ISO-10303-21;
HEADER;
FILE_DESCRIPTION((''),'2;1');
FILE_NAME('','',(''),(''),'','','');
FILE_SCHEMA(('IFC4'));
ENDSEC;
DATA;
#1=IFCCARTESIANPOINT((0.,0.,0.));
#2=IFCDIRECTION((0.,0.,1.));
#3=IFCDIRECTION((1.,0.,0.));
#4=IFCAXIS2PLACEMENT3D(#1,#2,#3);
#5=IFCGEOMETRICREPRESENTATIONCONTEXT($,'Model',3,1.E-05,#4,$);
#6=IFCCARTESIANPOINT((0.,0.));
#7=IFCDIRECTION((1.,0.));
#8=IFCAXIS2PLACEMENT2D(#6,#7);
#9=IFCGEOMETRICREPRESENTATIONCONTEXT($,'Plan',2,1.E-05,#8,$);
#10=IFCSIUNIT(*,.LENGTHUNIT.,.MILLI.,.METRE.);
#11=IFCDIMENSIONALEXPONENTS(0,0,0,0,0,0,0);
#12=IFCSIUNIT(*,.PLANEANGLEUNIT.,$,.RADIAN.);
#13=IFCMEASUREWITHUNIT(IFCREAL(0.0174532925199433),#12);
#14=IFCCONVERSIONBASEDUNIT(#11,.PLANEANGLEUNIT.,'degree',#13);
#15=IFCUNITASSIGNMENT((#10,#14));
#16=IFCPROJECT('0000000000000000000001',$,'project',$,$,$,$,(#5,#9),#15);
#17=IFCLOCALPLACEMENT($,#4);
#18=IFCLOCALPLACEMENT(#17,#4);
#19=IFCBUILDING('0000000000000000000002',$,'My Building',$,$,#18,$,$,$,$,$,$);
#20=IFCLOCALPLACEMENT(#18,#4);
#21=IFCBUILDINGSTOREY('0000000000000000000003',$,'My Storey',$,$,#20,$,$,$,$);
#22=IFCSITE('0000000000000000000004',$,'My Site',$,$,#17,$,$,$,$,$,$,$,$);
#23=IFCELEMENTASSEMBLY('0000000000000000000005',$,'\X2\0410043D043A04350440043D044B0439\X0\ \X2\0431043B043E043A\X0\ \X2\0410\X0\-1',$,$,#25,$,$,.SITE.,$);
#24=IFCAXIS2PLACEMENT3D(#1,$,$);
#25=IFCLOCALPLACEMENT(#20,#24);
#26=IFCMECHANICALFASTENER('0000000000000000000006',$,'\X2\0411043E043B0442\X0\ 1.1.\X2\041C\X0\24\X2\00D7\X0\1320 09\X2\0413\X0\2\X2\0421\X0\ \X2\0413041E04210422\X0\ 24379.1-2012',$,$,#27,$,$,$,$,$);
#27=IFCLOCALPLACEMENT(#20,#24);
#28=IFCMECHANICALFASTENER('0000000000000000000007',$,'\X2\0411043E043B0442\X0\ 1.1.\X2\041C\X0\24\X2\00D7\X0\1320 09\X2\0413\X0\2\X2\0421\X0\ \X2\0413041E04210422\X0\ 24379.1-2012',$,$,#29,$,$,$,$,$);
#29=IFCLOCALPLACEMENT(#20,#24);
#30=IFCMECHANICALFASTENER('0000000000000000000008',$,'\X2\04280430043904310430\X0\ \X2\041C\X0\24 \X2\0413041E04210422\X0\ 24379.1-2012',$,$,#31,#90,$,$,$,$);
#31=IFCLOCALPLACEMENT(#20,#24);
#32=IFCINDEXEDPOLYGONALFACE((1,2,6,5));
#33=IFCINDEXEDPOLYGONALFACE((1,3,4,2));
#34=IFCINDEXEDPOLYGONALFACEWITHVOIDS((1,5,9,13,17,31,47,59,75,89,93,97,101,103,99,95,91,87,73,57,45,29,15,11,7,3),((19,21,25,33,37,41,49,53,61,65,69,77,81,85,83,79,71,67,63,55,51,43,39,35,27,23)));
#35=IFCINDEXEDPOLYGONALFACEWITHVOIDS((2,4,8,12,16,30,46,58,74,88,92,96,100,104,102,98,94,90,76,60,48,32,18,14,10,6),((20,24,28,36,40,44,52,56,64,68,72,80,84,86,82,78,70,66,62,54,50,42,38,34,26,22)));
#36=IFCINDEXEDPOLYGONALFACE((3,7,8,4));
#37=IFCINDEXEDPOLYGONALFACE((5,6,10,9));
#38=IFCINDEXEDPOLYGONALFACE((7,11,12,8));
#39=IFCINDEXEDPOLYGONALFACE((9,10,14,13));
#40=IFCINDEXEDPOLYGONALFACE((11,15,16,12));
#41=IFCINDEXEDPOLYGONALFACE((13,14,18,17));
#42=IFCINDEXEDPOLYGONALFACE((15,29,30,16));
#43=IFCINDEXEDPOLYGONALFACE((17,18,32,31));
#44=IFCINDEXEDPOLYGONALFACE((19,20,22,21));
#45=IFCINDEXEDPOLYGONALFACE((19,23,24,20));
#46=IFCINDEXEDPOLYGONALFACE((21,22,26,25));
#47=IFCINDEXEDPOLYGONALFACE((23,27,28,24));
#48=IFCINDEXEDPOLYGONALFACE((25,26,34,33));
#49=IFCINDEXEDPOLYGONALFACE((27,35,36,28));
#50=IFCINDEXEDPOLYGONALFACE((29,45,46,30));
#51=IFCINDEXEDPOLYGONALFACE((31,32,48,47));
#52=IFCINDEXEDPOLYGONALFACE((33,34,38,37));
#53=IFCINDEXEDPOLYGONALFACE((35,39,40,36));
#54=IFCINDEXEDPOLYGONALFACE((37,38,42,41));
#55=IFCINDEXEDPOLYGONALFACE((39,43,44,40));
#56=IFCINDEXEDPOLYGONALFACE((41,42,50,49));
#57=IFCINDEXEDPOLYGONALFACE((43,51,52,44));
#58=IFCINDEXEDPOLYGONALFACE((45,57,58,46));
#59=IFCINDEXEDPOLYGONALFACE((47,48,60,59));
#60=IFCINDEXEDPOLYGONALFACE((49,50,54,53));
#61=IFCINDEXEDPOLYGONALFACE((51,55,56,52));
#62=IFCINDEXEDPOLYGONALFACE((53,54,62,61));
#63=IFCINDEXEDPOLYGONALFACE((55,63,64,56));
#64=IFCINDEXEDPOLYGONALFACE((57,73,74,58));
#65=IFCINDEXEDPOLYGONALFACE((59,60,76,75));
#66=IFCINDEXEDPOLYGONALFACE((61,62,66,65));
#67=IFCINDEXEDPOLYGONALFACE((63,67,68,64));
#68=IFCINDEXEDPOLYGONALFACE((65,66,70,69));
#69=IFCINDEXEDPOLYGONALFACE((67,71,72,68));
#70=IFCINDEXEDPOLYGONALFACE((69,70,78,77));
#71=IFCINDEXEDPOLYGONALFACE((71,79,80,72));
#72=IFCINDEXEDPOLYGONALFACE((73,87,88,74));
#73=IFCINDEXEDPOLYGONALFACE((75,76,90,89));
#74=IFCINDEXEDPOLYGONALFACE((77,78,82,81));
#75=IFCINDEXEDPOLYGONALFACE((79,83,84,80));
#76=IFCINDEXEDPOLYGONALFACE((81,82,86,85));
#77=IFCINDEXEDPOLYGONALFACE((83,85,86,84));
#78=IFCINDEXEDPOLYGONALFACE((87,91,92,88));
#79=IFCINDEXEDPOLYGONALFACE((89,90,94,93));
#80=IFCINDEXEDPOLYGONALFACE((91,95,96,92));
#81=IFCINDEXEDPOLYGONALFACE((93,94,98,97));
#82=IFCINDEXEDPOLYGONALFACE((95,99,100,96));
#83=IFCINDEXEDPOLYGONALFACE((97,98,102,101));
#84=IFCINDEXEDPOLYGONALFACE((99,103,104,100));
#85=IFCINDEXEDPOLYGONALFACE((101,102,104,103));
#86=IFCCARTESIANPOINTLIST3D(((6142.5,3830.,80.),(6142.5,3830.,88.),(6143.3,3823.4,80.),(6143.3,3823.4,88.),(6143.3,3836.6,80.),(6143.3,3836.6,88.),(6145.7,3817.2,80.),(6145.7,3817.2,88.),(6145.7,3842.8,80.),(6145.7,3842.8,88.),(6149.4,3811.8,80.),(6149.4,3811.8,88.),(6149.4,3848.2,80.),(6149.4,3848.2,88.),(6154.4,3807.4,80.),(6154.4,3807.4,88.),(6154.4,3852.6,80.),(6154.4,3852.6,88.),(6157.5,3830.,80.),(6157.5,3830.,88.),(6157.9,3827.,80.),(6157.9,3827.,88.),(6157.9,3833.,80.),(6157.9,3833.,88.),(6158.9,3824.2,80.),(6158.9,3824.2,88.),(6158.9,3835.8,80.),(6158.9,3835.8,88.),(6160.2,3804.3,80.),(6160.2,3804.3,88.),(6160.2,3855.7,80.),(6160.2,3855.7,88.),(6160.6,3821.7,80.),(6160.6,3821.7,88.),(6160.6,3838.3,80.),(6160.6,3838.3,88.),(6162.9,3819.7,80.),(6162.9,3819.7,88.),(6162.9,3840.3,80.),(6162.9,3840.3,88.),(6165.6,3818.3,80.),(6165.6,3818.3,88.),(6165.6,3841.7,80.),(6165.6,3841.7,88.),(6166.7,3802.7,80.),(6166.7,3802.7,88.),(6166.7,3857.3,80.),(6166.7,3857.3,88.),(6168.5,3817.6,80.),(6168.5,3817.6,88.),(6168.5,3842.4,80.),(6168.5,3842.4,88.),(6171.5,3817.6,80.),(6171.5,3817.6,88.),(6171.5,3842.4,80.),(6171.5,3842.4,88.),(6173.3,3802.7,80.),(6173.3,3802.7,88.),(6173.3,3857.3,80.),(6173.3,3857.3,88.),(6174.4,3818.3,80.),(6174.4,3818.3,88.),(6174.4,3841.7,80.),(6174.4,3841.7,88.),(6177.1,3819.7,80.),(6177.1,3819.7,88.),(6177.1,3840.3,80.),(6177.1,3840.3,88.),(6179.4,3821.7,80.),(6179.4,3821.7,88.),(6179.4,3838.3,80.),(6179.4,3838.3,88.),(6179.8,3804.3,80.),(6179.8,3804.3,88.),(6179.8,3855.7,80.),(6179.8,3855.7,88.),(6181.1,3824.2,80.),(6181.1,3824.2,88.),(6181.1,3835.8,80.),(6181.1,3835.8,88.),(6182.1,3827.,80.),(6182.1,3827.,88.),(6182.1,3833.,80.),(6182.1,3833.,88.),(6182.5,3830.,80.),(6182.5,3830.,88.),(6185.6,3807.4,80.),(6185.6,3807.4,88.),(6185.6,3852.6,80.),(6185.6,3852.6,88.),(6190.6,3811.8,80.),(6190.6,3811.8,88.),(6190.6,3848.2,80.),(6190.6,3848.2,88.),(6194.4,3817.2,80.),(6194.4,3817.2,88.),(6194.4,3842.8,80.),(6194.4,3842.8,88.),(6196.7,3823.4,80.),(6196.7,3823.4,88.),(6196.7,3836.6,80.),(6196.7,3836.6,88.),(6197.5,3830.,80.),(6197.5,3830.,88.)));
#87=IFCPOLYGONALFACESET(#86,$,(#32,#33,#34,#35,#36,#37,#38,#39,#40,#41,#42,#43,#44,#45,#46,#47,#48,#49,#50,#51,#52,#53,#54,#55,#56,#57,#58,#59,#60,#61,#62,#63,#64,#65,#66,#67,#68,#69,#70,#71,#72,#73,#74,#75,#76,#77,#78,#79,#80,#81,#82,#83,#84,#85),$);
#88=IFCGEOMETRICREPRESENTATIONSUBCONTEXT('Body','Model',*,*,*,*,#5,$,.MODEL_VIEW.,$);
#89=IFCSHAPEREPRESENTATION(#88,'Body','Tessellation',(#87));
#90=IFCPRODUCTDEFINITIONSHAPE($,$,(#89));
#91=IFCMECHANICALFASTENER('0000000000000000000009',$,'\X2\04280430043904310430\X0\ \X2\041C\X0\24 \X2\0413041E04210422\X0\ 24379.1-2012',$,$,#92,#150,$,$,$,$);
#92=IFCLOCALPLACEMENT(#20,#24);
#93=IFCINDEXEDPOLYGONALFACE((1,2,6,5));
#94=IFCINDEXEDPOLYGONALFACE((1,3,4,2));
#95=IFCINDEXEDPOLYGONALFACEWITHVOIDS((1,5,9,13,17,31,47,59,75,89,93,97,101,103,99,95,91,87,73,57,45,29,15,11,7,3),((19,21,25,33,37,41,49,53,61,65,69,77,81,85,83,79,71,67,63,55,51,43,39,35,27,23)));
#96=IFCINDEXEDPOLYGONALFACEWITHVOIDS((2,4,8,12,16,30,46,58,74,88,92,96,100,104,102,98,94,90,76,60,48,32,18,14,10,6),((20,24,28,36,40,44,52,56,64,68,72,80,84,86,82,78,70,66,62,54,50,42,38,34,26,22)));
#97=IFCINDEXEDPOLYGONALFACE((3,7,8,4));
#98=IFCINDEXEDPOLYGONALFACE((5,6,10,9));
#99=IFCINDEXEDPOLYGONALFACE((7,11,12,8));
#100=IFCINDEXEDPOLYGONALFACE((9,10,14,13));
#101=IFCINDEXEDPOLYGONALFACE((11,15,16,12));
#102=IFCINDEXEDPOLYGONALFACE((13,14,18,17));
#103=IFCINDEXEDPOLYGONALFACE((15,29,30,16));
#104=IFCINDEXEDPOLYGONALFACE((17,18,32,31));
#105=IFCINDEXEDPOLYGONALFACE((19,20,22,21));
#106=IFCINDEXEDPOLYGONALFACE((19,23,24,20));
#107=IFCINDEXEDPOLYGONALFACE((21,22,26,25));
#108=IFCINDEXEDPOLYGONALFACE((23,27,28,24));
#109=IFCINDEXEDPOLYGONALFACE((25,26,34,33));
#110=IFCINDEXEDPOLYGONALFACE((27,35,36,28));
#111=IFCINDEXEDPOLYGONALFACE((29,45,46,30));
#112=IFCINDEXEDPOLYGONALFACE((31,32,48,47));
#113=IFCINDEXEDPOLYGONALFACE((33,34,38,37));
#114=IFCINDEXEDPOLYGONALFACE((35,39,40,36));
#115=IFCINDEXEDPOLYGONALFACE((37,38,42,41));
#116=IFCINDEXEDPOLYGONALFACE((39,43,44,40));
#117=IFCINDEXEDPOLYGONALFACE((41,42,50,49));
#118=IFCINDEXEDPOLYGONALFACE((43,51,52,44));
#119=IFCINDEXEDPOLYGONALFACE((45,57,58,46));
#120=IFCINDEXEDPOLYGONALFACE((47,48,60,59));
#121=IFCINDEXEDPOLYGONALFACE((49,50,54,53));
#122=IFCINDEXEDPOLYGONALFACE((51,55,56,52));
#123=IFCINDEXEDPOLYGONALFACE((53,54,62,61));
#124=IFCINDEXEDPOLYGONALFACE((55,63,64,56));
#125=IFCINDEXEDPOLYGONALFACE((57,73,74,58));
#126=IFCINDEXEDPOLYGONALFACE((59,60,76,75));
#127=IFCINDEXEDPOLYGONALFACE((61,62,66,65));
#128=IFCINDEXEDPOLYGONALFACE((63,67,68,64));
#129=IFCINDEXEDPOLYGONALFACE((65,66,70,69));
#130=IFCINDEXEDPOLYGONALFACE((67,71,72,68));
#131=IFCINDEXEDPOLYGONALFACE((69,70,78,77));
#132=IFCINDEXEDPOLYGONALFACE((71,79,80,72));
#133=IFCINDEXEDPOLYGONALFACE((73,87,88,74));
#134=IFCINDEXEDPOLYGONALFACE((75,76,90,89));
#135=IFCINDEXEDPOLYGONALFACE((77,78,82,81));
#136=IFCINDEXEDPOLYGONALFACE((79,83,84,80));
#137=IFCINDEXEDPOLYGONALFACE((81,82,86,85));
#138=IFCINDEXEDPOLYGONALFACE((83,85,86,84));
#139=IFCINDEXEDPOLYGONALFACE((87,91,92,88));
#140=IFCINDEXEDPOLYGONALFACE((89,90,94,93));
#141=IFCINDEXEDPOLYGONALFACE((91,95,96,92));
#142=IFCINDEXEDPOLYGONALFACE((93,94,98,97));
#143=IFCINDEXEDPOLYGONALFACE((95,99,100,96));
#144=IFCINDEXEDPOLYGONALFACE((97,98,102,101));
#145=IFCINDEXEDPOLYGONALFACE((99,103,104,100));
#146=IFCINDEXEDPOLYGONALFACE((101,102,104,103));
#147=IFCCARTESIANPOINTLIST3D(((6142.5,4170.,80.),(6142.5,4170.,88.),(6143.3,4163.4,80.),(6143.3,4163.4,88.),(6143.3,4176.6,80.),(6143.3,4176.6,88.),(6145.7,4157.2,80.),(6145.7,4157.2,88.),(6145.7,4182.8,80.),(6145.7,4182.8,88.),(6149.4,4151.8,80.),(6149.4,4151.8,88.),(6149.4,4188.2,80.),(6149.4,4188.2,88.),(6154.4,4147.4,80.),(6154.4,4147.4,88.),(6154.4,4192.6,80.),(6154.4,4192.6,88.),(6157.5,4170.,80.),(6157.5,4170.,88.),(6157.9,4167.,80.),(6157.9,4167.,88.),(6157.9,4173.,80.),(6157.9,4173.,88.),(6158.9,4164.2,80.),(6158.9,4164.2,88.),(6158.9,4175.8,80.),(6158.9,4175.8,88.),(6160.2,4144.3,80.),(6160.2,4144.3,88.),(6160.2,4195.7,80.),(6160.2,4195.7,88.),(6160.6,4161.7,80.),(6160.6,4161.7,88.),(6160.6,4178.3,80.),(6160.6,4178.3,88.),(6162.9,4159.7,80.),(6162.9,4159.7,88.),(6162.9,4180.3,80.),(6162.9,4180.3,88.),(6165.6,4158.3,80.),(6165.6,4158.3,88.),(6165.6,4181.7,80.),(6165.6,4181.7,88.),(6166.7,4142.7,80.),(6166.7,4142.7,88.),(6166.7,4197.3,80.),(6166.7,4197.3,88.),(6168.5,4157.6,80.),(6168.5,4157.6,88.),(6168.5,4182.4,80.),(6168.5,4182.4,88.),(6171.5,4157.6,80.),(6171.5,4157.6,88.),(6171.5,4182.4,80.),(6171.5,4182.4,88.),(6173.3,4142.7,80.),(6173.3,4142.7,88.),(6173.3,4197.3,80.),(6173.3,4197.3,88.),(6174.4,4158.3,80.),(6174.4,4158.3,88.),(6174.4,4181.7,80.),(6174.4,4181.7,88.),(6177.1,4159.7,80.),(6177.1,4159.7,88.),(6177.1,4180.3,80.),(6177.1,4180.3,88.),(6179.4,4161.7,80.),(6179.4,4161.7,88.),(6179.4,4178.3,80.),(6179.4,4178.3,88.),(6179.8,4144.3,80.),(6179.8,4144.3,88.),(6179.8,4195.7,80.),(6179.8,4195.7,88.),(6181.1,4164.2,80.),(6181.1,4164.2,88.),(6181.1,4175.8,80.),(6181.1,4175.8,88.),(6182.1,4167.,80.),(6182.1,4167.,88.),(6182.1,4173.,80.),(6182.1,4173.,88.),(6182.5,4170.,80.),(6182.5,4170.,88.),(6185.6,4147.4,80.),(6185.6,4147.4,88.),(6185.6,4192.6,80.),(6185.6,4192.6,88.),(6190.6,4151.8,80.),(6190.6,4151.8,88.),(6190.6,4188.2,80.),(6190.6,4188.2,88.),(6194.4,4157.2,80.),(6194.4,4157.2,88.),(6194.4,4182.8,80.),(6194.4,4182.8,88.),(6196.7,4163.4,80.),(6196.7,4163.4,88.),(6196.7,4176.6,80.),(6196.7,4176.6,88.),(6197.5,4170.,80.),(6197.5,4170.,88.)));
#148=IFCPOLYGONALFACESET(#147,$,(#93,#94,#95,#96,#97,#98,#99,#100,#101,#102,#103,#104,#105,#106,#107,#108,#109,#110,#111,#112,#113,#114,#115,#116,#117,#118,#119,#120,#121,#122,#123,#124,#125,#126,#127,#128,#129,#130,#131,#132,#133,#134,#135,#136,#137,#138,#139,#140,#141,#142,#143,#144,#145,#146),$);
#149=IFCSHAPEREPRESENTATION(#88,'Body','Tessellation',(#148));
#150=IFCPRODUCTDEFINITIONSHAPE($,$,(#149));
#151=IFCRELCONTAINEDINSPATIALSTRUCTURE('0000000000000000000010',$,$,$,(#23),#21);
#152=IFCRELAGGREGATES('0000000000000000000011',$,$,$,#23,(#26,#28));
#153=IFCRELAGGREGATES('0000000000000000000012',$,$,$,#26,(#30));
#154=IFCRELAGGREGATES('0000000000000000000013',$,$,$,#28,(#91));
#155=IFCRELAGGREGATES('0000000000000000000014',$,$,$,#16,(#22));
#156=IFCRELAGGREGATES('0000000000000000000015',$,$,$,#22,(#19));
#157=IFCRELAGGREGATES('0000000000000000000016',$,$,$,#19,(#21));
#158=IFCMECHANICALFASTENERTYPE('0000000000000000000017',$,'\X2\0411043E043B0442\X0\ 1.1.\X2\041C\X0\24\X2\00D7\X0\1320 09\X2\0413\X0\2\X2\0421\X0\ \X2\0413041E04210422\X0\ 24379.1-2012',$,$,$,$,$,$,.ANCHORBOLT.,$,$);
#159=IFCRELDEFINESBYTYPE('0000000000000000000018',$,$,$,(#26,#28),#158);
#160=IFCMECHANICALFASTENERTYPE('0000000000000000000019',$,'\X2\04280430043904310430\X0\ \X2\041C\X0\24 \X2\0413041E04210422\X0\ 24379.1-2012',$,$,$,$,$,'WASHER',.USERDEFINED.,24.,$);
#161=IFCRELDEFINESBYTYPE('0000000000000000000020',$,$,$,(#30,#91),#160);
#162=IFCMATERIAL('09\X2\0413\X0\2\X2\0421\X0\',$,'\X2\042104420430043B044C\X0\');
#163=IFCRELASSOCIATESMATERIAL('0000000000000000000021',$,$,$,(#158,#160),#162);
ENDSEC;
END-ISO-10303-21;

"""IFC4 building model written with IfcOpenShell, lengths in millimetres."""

from ifc_helpers import new_model, entity, si_unit, converted_unit, frame, origin_with_axes, origin_2d_with_axis, place, context, subcontext, project, spatial, polyline, outline, extrude, source, transform, mapped, material, type_object, type_shapes, element, aggregate, save


model = new_model("IFC4")

# Units and contexts
model_context = context("Model", 3, precision=1e-05, world=origin_with_axes())
plan_context = context("Plan", 2, precision=1e-05, world=origin_2d_with_axis())
body_context = subcontext(model_context, "Body", "Model", "MODEL_VIEW")
ifc_project = project(units=[si_unit("LENGTHUNIT", "METRE", prefix="MILLI"), converted_unit("PLANEANGLEUNIT", "degree", entity("IfcReal", 0.0174532925199433), si_unit("PLANEANGLEUNIT", "RADIAN"), dimensions=[0, 0, 0, 0, 0, 0, 0])], contexts=[model_context, plan_context])

# Site, building, storey
site_placement = place(None, origin_with_axes())
site = spatial("IfcSite", under=ifc_project, at=site_placement, Name="My Site")
building_placement = place(site_placement, origin_with_axes())
building = spatial("IfcBuilding", under=site, at=building_placement, Name="My Building")
storey_placement = place(building_placement, origin_with_axes())
storey = spatial("IfcBuildingStorey", under=building, at=storey_placement, Name="My Storey")

# Element assembly, mechanical fasteners
assembly_1_placement = place(storey_placement, frame((6000.0, 4000.0, 0.0), z_axis=(0.0, 0.0, 1.0), x_axis=(1.0, 0.0, 0.0)))
assembly_1 = element("IfcElementAssembly", 1, at=assembly_1_placement, inside=storey, Name="Анкерный блок А-1", AssemblyPlace="SITE")
ifc_material_1 = material(Name="09Г2С", Category="Сталь")
mechanical_fastener_type_1 = type_object("IfcMechanicalFastenerType", Name="Болт 1.1.М24×1320 09Г2С ГОСТ 24379.1-2012", PredefinedType="ANCHORBOLT", material=ifc_material_1)
mechanical_fastener_1_placement = place(assembly_1_placement, frame((170.0, -170.0, 0.0), z_axis=(0.0, 0.0, 1.0), x_axis=(1.0, 0.0, 0.0)))
mechanical_fastener_1 = element("IfcMechanicalFastener", 2, at=mechanical_fastener_1_placement, type_object=mechanical_fastener_type_1, Name="Болт 1.1.М24×1320 09Г2С ГОСТ 24379.1-2012")
mechanical_fastener_2_placement = place(assembly_1_placement, frame((170.0, 170.0, 0.0), z_axis=(0.0, 0.0, 1.0), x_axis=(-1.0, 0.0, 0.0)))
mechanical_fastener_2 = element("IfcMechanicalFastener", 3, at=mechanical_fastener_2_placement, type_object=mechanical_fastener_type_1, Name="Болт 1.1.М24×1320 09Г2С ГОСТ 24379.1-2012")
aggregate(assembly_1, [mechanical_fastener_1, mechanical_fastener_2])

# Mechanical fasteners
mechanical_fastener_type_2 = type_object("IfcMechanicalFastenerType", Name="Шайба М24 ГОСТ 24379.1-2012", ElementType="WASHER", NominalDiameter=24.0, PredefinedType="USERDEFINED", material=ifc_material_1)
shared_shape_1 = source(origin_with_axes(), body_context, "Body", "SweptSolid", [
    extrude(outline(polyline([(27.5, 0.0), (26.7, 6.6), (24.4, 12.8), (20.6, 18.2), (15.6, 22.6), (9.8, 25.7), (3.3, 27.3), (-3.3, 27.3), (-9.8, 25.7), (-15.6, 22.6), (-20.6, 18.2), (-24.4, 12.8), (-26.7, 6.6), (-27.5, 0.0), (-26.7, -6.6), (-24.4, -12.8), (-20.6, -18.2), (-15.6, -22.6), (-9.8, -25.7), (-3.3, -27.3), (3.3, -27.3), (9.8, -25.7), (15.6, -22.6), (20.6, -18.2), (24.4, -12.8), (26.7, -6.6), (27.5, 0.0)]), holes=[polyline([(-4.4, -11.7), (-7.1, -10.3), (-9.4, -8.3), (-11.1, -5.8), (-12.1, -3.0), (-12.5, 0.0), (-12.1, 3.0), (-11.1, 5.8), (-9.4, 8.3), (-7.1, 10.3), (-4.4, 11.7), (-1.5, 12.4), (1.5, 12.4), (4.4, 11.7), (7.1, 10.3), (9.4, 8.3), (11.1, 5.8), (12.1, 3.0), (12.5, 0.0), (12.1, -3.0), (11.1, -5.8), (9.4, -8.3), (7.1, -10.3), (4.4, -11.7), (1.5, -12.4), (-1.5, -12.4), (-4.4, -11.7)])]), frame((0.0, 0.0, 0.0), z_axis=(0.0, 0.0, 1.0), x_axis=(0.120537, -0.992709, 0.0)), (0.0, 0.0, 1.0), 8.0),
])
type_shapes(mechanical_fastener_type_2, [shared_shape_1])
mechanical_fastener_3_placement = place(mechanical_fastener_1_placement, frame((0.0, 0.0, 80.0), z_axis=(0.0, 0.0, 1.0), x_axis=(1.0, 0.0, 0.0)))
mechanical_fastener_3 = element("IfcMechanicalFastener", 4, at=mechanical_fastener_3_placement, type_object=mechanical_fastener_type_2, Name="Шайба М24 ГОСТ 24379.1-2012", context=body_context, shape_type="MappedRepresentation", body=[
    mapped(shared_shape_1, transform((0.0, 0.0, 0.0), x_axis=(1.0, 0.0, 0.0), y_axis=(0.0, 1.0, 0.0), z_axis=(0.0, 0.0, 1.0), scale=1.0)),
])
aggregate(mechanical_fastener_1, [mechanical_fastener_3])
mechanical_fastener_4_placement = place(mechanical_fastener_2_placement, frame((0.0, 0.0, 80.0), z_axis=(0.0, 0.0, 1.0), x_axis=(1.0, 0.0, 0.0)))
mechanical_fastener_4 = element("IfcMechanicalFastener", 5, at=mechanical_fastener_4_placement, type_object=mechanical_fastener_type_2, Name="Шайба М24 ГОСТ 24379.1-2012", context=body_context, shape_type="MappedRepresentation", body=[
    mapped(shared_shape_1, transform((0.0, 0.0, 0.0), x_axis=(1.0, 0.0, 0.0), y_axis=(0.0, 1.0, 0.0), z_axis=(0.0, 0.0, 1.0), scale=1.0)),
])
aggregate(mechanical_fastener_2, [mechanical_fastener_4])

save(model, "model.ifc")
